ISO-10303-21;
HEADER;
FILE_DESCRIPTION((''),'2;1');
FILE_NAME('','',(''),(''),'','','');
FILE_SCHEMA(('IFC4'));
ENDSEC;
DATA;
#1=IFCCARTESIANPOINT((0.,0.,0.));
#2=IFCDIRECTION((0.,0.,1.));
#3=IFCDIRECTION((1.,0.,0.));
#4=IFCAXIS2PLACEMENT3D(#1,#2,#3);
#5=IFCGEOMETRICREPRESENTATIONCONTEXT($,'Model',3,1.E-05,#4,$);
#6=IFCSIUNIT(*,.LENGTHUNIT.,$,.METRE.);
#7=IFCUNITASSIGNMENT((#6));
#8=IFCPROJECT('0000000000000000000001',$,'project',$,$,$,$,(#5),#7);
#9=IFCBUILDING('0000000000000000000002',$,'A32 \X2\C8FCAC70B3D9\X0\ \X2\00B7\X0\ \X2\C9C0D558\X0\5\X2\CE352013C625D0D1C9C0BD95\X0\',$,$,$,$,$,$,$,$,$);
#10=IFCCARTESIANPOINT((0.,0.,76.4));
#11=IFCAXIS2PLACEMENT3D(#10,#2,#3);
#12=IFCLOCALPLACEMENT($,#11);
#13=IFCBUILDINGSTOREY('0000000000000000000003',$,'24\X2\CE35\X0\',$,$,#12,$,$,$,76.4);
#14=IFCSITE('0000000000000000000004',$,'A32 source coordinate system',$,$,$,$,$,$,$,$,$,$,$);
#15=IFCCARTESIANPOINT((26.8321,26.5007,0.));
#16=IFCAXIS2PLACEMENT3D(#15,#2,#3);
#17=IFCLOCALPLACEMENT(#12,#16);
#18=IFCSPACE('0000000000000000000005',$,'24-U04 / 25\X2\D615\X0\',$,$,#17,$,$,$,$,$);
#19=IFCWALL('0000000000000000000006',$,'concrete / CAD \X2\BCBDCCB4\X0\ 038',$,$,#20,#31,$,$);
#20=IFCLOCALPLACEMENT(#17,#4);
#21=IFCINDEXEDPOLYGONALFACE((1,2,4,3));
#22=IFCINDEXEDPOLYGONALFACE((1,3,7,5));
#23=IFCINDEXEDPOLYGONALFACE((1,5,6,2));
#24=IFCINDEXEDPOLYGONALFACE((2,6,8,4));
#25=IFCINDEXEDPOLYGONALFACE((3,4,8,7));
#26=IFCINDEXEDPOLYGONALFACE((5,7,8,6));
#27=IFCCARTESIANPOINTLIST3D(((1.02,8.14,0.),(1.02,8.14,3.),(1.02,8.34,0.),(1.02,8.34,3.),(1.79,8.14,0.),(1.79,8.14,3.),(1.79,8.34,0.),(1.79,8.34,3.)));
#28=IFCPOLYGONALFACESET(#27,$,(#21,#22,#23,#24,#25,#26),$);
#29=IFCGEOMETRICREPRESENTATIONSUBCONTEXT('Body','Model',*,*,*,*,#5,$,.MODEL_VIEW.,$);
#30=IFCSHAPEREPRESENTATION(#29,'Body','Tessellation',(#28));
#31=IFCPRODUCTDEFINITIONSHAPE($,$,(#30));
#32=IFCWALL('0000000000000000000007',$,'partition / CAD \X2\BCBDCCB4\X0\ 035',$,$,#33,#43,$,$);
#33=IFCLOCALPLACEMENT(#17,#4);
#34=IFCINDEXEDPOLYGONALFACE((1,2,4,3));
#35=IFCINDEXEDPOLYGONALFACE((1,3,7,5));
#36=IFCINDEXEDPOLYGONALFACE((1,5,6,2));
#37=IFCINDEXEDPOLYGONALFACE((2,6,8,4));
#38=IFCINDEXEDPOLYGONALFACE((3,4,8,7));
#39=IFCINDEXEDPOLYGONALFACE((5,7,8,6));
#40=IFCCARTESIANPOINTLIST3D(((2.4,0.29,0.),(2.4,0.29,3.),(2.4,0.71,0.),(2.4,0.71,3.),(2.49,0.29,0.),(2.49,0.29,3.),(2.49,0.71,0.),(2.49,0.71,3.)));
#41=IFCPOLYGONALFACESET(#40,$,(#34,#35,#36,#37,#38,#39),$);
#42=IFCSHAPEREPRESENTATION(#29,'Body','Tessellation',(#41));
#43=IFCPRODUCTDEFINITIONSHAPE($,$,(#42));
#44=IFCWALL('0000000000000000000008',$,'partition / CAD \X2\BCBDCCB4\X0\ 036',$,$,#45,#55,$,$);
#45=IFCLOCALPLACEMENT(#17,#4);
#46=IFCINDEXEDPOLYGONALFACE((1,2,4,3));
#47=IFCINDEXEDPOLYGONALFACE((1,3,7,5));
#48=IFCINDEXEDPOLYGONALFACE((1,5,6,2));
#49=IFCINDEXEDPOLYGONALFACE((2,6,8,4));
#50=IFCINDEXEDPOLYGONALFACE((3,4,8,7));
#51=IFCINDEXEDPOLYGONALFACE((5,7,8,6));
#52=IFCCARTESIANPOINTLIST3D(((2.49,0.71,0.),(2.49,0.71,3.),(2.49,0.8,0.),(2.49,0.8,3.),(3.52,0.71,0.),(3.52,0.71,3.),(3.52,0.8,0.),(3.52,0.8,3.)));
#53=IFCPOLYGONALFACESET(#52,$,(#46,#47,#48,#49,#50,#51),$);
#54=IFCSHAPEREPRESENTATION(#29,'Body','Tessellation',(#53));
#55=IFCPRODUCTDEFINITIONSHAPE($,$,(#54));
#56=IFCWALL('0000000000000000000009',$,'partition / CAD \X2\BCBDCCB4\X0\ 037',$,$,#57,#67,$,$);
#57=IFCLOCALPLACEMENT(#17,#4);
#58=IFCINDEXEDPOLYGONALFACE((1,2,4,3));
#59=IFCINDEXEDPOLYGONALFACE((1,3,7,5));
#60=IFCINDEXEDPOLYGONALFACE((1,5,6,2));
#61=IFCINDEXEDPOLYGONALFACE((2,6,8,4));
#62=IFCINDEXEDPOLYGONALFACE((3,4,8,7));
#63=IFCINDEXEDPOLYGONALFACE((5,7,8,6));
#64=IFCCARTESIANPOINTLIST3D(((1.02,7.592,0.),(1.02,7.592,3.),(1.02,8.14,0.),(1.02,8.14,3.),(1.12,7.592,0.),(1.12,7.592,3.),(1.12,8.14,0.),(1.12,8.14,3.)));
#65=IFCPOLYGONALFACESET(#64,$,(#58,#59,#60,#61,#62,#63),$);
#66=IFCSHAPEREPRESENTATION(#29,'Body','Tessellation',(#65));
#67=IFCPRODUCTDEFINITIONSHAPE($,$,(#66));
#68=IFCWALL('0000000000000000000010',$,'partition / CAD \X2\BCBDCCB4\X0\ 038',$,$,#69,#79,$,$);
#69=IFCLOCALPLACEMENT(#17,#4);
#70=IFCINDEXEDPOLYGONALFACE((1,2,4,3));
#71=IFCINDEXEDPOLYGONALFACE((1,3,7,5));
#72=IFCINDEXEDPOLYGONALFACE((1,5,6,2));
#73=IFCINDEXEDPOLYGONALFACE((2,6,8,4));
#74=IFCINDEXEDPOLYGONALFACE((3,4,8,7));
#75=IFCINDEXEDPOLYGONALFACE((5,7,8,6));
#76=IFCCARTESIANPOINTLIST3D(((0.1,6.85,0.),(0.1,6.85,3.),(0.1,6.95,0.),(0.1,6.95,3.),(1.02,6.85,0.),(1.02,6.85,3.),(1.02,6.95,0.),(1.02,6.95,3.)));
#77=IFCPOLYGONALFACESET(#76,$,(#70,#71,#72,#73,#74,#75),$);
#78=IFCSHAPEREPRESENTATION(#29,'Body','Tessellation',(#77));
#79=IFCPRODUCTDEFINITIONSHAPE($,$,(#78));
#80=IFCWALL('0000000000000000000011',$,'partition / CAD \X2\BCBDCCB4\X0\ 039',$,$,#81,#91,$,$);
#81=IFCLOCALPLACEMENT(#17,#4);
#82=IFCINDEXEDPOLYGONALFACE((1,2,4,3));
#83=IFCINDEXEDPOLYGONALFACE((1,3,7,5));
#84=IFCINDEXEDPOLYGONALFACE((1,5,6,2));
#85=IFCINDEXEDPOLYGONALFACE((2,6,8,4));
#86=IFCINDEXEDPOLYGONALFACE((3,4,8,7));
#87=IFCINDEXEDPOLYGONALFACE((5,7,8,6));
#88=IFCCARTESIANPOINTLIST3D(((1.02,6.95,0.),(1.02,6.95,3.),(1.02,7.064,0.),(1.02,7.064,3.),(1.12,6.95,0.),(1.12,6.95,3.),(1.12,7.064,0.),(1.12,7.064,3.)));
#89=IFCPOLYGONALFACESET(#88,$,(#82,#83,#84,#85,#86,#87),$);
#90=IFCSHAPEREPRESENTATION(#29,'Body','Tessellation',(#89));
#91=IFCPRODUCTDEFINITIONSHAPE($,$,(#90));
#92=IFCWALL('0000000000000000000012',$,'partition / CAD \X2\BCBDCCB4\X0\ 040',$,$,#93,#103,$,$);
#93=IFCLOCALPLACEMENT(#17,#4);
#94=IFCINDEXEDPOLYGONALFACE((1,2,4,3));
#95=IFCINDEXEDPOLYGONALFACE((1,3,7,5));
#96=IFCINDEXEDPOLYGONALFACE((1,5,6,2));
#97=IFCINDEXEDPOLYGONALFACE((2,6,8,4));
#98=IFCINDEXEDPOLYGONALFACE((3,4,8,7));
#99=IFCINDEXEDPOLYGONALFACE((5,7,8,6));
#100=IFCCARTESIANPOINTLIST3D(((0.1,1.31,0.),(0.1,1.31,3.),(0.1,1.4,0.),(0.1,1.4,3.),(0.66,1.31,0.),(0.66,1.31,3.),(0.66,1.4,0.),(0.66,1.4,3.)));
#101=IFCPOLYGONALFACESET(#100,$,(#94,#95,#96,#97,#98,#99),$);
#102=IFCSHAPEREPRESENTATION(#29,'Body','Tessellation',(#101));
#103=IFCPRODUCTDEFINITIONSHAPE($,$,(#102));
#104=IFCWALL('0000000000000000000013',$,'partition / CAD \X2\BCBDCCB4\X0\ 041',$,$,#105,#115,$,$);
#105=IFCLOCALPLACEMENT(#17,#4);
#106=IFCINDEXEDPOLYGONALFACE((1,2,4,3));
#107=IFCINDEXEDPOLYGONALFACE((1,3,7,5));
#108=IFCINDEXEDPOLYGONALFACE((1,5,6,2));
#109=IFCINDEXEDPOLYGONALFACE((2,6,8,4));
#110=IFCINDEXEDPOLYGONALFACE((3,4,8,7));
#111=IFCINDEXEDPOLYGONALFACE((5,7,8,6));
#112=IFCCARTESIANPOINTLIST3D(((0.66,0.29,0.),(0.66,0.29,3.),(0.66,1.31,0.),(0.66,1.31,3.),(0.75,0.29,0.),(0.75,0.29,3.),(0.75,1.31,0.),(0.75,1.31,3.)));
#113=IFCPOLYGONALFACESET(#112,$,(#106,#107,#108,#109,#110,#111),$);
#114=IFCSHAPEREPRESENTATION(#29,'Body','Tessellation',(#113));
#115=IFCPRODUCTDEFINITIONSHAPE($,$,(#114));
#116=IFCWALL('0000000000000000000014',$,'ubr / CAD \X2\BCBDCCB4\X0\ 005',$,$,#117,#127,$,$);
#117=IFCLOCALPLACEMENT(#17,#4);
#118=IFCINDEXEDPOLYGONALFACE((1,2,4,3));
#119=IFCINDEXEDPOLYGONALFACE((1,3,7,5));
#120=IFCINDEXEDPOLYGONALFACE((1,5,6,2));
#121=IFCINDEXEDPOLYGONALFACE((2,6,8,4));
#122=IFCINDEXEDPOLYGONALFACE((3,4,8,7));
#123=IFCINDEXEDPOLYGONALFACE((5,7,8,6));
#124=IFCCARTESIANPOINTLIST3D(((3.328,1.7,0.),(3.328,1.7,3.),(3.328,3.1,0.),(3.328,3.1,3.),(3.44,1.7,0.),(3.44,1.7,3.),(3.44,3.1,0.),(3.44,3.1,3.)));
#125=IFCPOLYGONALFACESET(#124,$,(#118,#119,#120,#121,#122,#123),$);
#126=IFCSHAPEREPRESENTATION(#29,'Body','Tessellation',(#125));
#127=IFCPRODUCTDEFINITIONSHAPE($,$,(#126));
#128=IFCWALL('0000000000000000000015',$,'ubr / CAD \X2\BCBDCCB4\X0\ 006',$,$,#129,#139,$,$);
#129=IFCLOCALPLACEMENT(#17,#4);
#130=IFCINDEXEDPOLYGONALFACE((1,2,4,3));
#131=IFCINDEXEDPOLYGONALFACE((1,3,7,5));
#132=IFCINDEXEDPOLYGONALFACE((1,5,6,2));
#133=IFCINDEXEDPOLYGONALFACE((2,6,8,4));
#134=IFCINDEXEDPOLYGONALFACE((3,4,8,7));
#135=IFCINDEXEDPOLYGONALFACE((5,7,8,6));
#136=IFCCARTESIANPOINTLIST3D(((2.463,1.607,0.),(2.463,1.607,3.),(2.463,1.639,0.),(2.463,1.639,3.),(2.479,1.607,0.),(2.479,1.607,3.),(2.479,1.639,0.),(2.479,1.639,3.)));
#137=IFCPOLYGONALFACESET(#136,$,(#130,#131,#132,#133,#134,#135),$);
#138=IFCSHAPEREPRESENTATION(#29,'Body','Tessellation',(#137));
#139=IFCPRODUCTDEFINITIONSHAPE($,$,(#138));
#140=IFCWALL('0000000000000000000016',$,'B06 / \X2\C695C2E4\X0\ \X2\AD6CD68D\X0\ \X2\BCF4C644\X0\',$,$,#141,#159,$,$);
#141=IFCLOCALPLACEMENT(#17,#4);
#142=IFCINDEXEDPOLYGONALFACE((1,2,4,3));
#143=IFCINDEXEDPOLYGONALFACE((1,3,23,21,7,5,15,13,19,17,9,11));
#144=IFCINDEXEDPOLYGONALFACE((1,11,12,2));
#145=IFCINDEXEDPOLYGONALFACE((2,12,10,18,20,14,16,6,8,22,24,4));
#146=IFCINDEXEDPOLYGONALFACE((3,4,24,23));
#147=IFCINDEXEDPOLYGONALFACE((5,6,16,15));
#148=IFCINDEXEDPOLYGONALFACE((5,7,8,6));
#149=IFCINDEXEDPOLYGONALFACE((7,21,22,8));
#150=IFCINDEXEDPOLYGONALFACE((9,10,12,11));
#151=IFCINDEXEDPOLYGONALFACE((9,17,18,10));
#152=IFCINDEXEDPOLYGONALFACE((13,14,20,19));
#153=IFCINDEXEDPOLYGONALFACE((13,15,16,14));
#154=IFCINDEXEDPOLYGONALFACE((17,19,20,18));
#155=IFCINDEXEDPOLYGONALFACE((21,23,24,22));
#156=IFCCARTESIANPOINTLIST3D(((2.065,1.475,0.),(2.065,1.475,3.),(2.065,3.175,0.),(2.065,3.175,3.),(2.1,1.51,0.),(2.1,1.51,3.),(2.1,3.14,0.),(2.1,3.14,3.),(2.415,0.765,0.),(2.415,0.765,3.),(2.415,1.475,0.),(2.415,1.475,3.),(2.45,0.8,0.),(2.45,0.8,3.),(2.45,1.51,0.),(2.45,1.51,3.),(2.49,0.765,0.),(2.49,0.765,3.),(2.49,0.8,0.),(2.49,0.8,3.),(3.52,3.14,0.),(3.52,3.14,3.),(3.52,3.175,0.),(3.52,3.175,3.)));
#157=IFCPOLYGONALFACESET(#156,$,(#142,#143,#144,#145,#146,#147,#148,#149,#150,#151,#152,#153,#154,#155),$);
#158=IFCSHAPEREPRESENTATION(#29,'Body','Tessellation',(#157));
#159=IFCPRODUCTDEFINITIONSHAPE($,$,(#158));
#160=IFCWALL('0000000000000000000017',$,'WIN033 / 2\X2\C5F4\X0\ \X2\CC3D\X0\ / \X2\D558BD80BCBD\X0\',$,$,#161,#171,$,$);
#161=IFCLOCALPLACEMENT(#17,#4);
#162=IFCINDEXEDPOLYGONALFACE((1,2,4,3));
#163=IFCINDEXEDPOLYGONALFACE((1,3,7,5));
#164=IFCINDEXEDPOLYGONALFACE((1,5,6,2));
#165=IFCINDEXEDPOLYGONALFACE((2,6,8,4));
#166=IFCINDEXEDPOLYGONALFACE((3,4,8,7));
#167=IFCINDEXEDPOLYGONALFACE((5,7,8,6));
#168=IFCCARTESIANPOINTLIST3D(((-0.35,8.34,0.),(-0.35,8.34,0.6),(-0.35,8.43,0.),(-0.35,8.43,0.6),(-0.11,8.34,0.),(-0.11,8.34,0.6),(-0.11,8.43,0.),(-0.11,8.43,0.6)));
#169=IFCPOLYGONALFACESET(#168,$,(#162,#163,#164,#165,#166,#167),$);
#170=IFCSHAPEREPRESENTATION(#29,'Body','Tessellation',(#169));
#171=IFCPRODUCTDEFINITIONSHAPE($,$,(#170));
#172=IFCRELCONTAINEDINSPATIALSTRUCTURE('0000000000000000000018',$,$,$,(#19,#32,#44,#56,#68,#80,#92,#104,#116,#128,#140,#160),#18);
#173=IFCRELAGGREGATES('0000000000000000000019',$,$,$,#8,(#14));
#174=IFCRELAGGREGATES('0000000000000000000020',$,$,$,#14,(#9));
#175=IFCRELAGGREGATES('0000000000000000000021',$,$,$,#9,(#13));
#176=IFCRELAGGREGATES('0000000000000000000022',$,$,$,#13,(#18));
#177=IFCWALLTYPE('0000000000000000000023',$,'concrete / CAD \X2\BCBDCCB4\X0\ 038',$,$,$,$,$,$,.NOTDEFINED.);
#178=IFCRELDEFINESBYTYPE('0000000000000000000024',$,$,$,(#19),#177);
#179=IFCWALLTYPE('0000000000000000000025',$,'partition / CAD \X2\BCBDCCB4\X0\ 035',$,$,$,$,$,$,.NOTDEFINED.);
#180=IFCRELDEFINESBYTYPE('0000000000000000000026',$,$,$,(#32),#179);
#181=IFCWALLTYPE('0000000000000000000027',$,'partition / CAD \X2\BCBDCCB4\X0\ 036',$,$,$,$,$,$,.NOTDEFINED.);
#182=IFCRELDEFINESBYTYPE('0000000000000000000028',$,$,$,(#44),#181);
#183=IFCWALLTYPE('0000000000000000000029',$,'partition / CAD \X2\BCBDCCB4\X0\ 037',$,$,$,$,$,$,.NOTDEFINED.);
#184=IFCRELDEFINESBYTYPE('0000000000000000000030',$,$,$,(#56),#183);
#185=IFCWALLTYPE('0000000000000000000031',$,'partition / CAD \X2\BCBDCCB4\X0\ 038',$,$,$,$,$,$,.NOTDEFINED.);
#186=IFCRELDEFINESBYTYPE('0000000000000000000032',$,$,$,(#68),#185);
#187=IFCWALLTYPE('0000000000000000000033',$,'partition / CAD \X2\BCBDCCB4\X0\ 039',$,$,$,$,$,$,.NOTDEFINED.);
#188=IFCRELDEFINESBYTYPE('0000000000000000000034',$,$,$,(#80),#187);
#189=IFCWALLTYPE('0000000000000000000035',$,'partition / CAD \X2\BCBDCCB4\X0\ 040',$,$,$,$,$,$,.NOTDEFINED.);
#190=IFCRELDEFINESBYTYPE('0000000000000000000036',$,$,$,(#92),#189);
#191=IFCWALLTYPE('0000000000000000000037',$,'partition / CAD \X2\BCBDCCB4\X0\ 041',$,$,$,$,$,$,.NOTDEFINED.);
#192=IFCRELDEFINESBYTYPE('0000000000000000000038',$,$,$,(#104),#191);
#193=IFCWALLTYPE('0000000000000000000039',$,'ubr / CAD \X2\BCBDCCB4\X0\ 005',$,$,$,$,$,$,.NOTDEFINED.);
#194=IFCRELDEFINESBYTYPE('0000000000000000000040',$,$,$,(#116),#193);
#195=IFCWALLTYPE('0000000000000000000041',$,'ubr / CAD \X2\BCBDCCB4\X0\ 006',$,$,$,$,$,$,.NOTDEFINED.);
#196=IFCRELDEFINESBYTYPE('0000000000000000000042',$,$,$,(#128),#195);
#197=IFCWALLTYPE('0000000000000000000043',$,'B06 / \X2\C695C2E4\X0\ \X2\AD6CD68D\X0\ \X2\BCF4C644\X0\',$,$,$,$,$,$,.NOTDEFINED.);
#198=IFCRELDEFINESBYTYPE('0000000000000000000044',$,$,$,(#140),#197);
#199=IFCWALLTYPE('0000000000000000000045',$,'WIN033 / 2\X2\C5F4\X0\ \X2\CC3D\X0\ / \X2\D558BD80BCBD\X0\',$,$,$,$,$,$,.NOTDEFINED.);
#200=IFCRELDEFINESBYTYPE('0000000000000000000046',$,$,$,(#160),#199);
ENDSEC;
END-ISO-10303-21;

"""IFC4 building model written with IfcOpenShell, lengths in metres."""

from ifc_helpers import new_model, si_unit, frame, origin, origin_with_axes, place, context, subcontext, project, spatial, polyline, outline, extrude, source, transform, mapped, type_object, type_shapes, element, save


model = new_model("IFC4")

# Units and contexts
model_context = context("Model", 3, precision=1e-05, world=origin_with_axes())
body_context = subcontext(model_context, "Body", "Model", "MODEL_VIEW")
ifc_project = project(units=[si_unit("LENGTHUNIT", "METRE")], contexts=[model_context])

# Site, building, storey, space
site = spatial("IfcSite", under=ifc_project, Name="A32 source coordinate system")
building = spatial("IfcBuilding", under=site, Name="A32 주거동 · 지하5층–옥탑지붕")
storey_placement = place(None, frame((0.0, 0.0, 76.4), z_axis=(0.0, 0.0, 1.0), x_axis=(1.0, 0.0, 0.0)))
storey = spatial("IfcBuildingStorey", under=building, at=storey_placement, Name="24층", Elevation=76.4)
space_1_placement = place(storey_placement, frame((26.8321, 26.5007, 0.0), z_axis=(0.0, 0.0, 1.0), x_axis=(1.0, 0.0, 0.0)))
space_1 = spatial("IfcSpace", under=storey, at=space_1_placement, Name="24-U04 / 25형")

# Walls
wall_type_1 = type_object("IfcWallType", Name="concrete / CAD 벽체 038", PredefinedType="NOTDEFINED")
shared_shape_1 = source(origin(), body_context, "Body", "SweptSolid", [
    extrude(outline(polyline([(1.02, 8.14), (1.02, 8.34), (1.79, 8.34), (1.79, 8.14), (1.02, 8.14)])), origin(), (0.0, 0.0, 1.0), 3.0),
])
type_shapes(wall_type_1, [shared_shape_1])
wall_1_placement = place(space_1_placement, origin_with_axes())
element("IfcWall", 1, at=wall_1_placement, inside=space_1, type_object=wall_type_1, Name="concrete / CAD 벽체 038", context=body_context, shape_type="MappedRepresentation", body=[
    mapped(shared_shape_1, transform((0.0, 0.0, 0.0), scale=1.0)),
])
wall_type_2 = type_object("IfcWallType", Name="partition / CAD 벽체 035", PredefinedType="NOTDEFINED")
shared_shape_2 = source(origin(), body_context, "Body", "SweptSolid", [
    extrude(outline(polyline([(2.49, 0.71), (2.49, 0.29), (2.4, 0.29), (2.4, 0.71), (2.49, 0.71)])), origin(), (0.0, 0.0, 1.0), 3.0),
])
type_shapes(wall_type_2, [shared_shape_2])
wall_2_placement = place(space_1_placement, origin_with_axes())
element("IfcWall", 2, at=wall_2_placement, inside=space_1, type_object=wall_type_2, Name="partition / CAD 벽체 035", context=body_context, shape_type="MappedRepresentation", body=[
    mapped(shared_shape_2, transform((0.0, 0.0, 0.0), scale=1.0)),
])
wall_type_3 = type_object("IfcWallType", Name="partition / CAD 벽체 036", PredefinedType="NOTDEFINED")
shared_shape_3 = source(origin(), body_context, "Body", "SweptSolid", [
    extrude(outline(polyline([(2.49, 0.8), (3.52, 0.8), (3.52, 0.71), (2.49, 0.71), (2.49, 0.8)])), origin(), (0.0, 0.0, 1.0), 3.0),
])
type_shapes(wall_type_3, [shared_shape_3])
wall_3_placement = place(space_1_placement, origin_with_axes())
element("IfcWall", 3, at=wall_3_placement, inside=space_1, type_object=wall_type_3, Name="partition / CAD 벽체 036", context=body_context, shape_type="MappedRepresentation", body=[
    mapped(shared_shape_3, transform((0.0, 0.0, 0.0), scale=1.0)),
])
wall_type_4 = type_object("IfcWallType", Name="partition / CAD 벽체 037", PredefinedType="NOTDEFINED")
shared_shape_4 = source(origin(), body_context, "Body", "SweptSolid", [
    extrude(outline(polyline([(1.02, 7.592), (1.02, 8.14), (1.12, 8.14), (1.12, 7.592), (1.02, 7.592)])), origin(), (0.0, 0.0, 1.0), 3.0),
])
type_shapes(wall_type_4, [shared_shape_4])
wall_4_placement = place(space_1_placement, origin_with_axes())
element("IfcWall", 4, at=wall_4_placement, inside=space_1, type_object=wall_type_4, Name="partition / CAD 벽체 037", context=body_context, shape_type="MappedRepresentation", body=[
    mapped(shared_shape_4, transform((0.0, 0.0, 0.0), scale=1.0)),
])
wall_type_5 = type_object("IfcWallType", Name="partition / CAD 벽체 038", PredefinedType="NOTDEFINED")
shared_shape_5 = source(origin(), body_context, "Body", "SweptSolid", [
    extrude(outline(polyline([(0.1, 6.95), (1.02, 6.95), (1.02, 6.85), (0.1, 6.85), (0.1, 6.95)])), origin(), (0.0, 0.0, 1.0), 3.0),
])
type_shapes(wall_type_5, [shared_shape_5])
wall_5_placement = place(space_1_placement, origin_with_axes())
element("IfcWall", 5, at=wall_5_placement, inside=space_1, type_object=wall_type_5, Name="partition / CAD 벽체 038", context=body_context, shape_type="MappedRepresentation", body=[
    mapped(shared_shape_5, transform((0.0, 0.0, 0.0), scale=1.0)),
])
wall_type_6 = type_object("IfcWallType", Name="partition / CAD 벽체 039", PredefinedType="NOTDEFINED")
shared_shape_6 = source(origin(), body_context, "Body", "SweptSolid", [
    extrude(outline(polyline([(1.02, 6.95), (1.02, 7.064), (1.12, 7.064), (1.12, 6.95), (1.02, 6.95)])), origin(), (0.0, 0.0, 1.0), 3.0),
])
type_shapes(wall_type_6, [shared_shape_6])
wall_6_placement = place(space_1_placement, origin_with_axes())
element("IfcWall", 6, at=wall_6_placement, inside=space_1, type_object=wall_type_6, Name="partition / CAD 벽체 039", context=body_context, shape_type="MappedRepresentation", body=[
    mapped(shared_shape_6, transform((0.0, 0.0, 0.0), scale=1.0)),
])
wall_type_7 = type_object("IfcWallType", Name="partition / CAD 벽체 040", PredefinedType="NOTDEFINED")
shared_shape_7 = source(origin(), body_context, "Body", "SweptSolid", [
    extrude(outline(polyline([(0.1, 1.4), (0.66, 1.4), (0.66, 1.31), (0.1, 1.31), (0.1, 1.4)])), origin(), (0.0, 0.0, 1.0), 3.0),
])
type_shapes(wall_type_7, [shared_shape_7])
wall_7_placement = place(space_1_placement, origin_with_axes())
element("IfcWall", 7, at=wall_7_placement, inside=space_1, type_object=wall_type_7, Name="partition / CAD 벽체 040", context=body_context, shape_type="MappedRepresentation", body=[
    mapped(shared_shape_7, transform((0.0, 0.0, 0.0), scale=1.0)),
])
wall_type_8 = type_object("IfcWallType", Name="partition / CAD 벽체 041", PredefinedType="NOTDEFINED")
shared_shape_8 = source(origin(), body_context, "Body", "SweptSolid", [
    extrude(outline(polyline([(0.75, 1.31), (0.75, 0.29), (0.66, 0.29), (0.66, 1.31), (0.75, 1.31)])), origin(), (0.0, 0.0, 1.0), 3.0),
])
type_shapes(wall_type_8, [shared_shape_8])
wall_8_placement = place(space_1_placement, origin_with_axes())
element("IfcWall", 8, at=wall_8_placement, inside=space_1, type_object=wall_type_8, Name="partition / CAD 벽체 041", context=body_context, shape_type="MappedRepresentation", body=[
    mapped(shared_shape_8, transform((0.0, 0.0, 0.0), scale=1.0)),
])
wall_type_9 = type_object("IfcWallType", Name="ubr / CAD 벽체 005", PredefinedType="NOTDEFINED")
shared_shape_9 = source(origin(), body_context, "Body", "SweptSolid", [
    extrude(outline(polyline([(3.44, 3.1), (3.44, 1.7), (3.328, 1.7), (3.328, 3.1), (3.44, 3.1)])), origin(), (0.0, 0.0, 1.0), 3.0),
])
type_shapes(wall_type_9, [shared_shape_9])
wall_9_placement = place(space_1_placement, origin_with_axes())
element("IfcWall", 9, at=wall_9_placement, inside=space_1, type_object=wall_type_9, Name="ubr / CAD 벽체 005", context=body_context, shape_type="MappedRepresentation", body=[
    mapped(shared_shape_9, transform((0.0, 0.0, 0.0), scale=1.0)),
])
wall_type_10 = type_object("IfcWallType", Name="ubr / CAD 벽체 006", PredefinedType="NOTDEFINED")
shared_shape_10 = source(origin(), body_context, "Body", "SweptSolid", [
    extrude(outline(polyline([(2.463, 1.639), (2.479, 1.639), (2.479, 1.607), (2.463, 1.607), (2.463, 1.639)])), origin(), (0.0, 0.0, 1.0), 3.0),
])
type_shapes(wall_type_10, [shared_shape_10])
wall_10_placement = place(space_1_placement, origin_with_axes())
element("IfcWall", 10, at=wall_10_placement, inside=space_1, type_object=wall_type_10, Name="ubr / CAD 벽체 006", context=body_context, shape_type="MappedRepresentation", body=[
    mapped(shared_shape_10, transform((0.0, 0.0, 0.0), scale=1.0)),
])
wall_type_11 = type_object("IfcWallType", Name="B06 / 욕실 구획 보완", PredefinedType="NOTDEFINED")
shared_shape_11 = source(origin(), body_context, "Body", "SweptSolid", [
    extrude(outline(polyline([(3.52, 3.14), (2.1, 3.14), (2.1, 1.51), (2.45, 1.51), (2.45, 0.8), (2.49, 0.8), (2.49, 0.765), (2.415, 0.765), (2.415, 1.475), (2.065, 1.475), (2.065, 3.175), (3.52, 3.175), (3.52, 3.14)])), origin(), (0.0, 0.0, 1.0), 3.0),
])
type_shapes(wall_type_11, [shared_shape_11])
wall_11_placement = place(space_1_placement, origin_with_axes())
element("IfcWall", 11, at=wall_11_placement, inside=space_1, type_object=wall_type_11, Name="B06 / 욕실 구획 보완", context=body_context, shape_type="MappedRepresentation", body=[
    mapped(shared_shape_11, transform((0.0, 0.0, 0.0), scale=1.0)),
])
wall_type_12 = type_object("IfcWallType", Name="WIN033 / 2열 창 / 하부벽", PredefinedType="NOTDEFINED")
shared_shape_12 = source(origin(), body_context, "Body", "SweptSolid", [
    extrude(outline(polyline([(-0.11, 8.43), (-0.11, 8.34), (-0.35, 8.34), (-0.35, 8.43), (-0.11, 8.43)])), origin(), (0.0, 0.0, 1.0), 0.6),
])
type_shapes(wall_type_12, [shared_shape_12])
wall_12_placement = place(space_1_placement, origin_with_axes())
element("IfcWall", 12, at=wall_12_placement, inside=space_1, type_object=wall_type_12, Name="WIN033 / 2열 창 / 하부벽", context=body_context, shape_type="MappedRepresentation", body=[
    mapped(shared_shape_12, transform((0.0, 0.0, 0.0), scale=1.0)),
])

save(model, "model.ifc")
